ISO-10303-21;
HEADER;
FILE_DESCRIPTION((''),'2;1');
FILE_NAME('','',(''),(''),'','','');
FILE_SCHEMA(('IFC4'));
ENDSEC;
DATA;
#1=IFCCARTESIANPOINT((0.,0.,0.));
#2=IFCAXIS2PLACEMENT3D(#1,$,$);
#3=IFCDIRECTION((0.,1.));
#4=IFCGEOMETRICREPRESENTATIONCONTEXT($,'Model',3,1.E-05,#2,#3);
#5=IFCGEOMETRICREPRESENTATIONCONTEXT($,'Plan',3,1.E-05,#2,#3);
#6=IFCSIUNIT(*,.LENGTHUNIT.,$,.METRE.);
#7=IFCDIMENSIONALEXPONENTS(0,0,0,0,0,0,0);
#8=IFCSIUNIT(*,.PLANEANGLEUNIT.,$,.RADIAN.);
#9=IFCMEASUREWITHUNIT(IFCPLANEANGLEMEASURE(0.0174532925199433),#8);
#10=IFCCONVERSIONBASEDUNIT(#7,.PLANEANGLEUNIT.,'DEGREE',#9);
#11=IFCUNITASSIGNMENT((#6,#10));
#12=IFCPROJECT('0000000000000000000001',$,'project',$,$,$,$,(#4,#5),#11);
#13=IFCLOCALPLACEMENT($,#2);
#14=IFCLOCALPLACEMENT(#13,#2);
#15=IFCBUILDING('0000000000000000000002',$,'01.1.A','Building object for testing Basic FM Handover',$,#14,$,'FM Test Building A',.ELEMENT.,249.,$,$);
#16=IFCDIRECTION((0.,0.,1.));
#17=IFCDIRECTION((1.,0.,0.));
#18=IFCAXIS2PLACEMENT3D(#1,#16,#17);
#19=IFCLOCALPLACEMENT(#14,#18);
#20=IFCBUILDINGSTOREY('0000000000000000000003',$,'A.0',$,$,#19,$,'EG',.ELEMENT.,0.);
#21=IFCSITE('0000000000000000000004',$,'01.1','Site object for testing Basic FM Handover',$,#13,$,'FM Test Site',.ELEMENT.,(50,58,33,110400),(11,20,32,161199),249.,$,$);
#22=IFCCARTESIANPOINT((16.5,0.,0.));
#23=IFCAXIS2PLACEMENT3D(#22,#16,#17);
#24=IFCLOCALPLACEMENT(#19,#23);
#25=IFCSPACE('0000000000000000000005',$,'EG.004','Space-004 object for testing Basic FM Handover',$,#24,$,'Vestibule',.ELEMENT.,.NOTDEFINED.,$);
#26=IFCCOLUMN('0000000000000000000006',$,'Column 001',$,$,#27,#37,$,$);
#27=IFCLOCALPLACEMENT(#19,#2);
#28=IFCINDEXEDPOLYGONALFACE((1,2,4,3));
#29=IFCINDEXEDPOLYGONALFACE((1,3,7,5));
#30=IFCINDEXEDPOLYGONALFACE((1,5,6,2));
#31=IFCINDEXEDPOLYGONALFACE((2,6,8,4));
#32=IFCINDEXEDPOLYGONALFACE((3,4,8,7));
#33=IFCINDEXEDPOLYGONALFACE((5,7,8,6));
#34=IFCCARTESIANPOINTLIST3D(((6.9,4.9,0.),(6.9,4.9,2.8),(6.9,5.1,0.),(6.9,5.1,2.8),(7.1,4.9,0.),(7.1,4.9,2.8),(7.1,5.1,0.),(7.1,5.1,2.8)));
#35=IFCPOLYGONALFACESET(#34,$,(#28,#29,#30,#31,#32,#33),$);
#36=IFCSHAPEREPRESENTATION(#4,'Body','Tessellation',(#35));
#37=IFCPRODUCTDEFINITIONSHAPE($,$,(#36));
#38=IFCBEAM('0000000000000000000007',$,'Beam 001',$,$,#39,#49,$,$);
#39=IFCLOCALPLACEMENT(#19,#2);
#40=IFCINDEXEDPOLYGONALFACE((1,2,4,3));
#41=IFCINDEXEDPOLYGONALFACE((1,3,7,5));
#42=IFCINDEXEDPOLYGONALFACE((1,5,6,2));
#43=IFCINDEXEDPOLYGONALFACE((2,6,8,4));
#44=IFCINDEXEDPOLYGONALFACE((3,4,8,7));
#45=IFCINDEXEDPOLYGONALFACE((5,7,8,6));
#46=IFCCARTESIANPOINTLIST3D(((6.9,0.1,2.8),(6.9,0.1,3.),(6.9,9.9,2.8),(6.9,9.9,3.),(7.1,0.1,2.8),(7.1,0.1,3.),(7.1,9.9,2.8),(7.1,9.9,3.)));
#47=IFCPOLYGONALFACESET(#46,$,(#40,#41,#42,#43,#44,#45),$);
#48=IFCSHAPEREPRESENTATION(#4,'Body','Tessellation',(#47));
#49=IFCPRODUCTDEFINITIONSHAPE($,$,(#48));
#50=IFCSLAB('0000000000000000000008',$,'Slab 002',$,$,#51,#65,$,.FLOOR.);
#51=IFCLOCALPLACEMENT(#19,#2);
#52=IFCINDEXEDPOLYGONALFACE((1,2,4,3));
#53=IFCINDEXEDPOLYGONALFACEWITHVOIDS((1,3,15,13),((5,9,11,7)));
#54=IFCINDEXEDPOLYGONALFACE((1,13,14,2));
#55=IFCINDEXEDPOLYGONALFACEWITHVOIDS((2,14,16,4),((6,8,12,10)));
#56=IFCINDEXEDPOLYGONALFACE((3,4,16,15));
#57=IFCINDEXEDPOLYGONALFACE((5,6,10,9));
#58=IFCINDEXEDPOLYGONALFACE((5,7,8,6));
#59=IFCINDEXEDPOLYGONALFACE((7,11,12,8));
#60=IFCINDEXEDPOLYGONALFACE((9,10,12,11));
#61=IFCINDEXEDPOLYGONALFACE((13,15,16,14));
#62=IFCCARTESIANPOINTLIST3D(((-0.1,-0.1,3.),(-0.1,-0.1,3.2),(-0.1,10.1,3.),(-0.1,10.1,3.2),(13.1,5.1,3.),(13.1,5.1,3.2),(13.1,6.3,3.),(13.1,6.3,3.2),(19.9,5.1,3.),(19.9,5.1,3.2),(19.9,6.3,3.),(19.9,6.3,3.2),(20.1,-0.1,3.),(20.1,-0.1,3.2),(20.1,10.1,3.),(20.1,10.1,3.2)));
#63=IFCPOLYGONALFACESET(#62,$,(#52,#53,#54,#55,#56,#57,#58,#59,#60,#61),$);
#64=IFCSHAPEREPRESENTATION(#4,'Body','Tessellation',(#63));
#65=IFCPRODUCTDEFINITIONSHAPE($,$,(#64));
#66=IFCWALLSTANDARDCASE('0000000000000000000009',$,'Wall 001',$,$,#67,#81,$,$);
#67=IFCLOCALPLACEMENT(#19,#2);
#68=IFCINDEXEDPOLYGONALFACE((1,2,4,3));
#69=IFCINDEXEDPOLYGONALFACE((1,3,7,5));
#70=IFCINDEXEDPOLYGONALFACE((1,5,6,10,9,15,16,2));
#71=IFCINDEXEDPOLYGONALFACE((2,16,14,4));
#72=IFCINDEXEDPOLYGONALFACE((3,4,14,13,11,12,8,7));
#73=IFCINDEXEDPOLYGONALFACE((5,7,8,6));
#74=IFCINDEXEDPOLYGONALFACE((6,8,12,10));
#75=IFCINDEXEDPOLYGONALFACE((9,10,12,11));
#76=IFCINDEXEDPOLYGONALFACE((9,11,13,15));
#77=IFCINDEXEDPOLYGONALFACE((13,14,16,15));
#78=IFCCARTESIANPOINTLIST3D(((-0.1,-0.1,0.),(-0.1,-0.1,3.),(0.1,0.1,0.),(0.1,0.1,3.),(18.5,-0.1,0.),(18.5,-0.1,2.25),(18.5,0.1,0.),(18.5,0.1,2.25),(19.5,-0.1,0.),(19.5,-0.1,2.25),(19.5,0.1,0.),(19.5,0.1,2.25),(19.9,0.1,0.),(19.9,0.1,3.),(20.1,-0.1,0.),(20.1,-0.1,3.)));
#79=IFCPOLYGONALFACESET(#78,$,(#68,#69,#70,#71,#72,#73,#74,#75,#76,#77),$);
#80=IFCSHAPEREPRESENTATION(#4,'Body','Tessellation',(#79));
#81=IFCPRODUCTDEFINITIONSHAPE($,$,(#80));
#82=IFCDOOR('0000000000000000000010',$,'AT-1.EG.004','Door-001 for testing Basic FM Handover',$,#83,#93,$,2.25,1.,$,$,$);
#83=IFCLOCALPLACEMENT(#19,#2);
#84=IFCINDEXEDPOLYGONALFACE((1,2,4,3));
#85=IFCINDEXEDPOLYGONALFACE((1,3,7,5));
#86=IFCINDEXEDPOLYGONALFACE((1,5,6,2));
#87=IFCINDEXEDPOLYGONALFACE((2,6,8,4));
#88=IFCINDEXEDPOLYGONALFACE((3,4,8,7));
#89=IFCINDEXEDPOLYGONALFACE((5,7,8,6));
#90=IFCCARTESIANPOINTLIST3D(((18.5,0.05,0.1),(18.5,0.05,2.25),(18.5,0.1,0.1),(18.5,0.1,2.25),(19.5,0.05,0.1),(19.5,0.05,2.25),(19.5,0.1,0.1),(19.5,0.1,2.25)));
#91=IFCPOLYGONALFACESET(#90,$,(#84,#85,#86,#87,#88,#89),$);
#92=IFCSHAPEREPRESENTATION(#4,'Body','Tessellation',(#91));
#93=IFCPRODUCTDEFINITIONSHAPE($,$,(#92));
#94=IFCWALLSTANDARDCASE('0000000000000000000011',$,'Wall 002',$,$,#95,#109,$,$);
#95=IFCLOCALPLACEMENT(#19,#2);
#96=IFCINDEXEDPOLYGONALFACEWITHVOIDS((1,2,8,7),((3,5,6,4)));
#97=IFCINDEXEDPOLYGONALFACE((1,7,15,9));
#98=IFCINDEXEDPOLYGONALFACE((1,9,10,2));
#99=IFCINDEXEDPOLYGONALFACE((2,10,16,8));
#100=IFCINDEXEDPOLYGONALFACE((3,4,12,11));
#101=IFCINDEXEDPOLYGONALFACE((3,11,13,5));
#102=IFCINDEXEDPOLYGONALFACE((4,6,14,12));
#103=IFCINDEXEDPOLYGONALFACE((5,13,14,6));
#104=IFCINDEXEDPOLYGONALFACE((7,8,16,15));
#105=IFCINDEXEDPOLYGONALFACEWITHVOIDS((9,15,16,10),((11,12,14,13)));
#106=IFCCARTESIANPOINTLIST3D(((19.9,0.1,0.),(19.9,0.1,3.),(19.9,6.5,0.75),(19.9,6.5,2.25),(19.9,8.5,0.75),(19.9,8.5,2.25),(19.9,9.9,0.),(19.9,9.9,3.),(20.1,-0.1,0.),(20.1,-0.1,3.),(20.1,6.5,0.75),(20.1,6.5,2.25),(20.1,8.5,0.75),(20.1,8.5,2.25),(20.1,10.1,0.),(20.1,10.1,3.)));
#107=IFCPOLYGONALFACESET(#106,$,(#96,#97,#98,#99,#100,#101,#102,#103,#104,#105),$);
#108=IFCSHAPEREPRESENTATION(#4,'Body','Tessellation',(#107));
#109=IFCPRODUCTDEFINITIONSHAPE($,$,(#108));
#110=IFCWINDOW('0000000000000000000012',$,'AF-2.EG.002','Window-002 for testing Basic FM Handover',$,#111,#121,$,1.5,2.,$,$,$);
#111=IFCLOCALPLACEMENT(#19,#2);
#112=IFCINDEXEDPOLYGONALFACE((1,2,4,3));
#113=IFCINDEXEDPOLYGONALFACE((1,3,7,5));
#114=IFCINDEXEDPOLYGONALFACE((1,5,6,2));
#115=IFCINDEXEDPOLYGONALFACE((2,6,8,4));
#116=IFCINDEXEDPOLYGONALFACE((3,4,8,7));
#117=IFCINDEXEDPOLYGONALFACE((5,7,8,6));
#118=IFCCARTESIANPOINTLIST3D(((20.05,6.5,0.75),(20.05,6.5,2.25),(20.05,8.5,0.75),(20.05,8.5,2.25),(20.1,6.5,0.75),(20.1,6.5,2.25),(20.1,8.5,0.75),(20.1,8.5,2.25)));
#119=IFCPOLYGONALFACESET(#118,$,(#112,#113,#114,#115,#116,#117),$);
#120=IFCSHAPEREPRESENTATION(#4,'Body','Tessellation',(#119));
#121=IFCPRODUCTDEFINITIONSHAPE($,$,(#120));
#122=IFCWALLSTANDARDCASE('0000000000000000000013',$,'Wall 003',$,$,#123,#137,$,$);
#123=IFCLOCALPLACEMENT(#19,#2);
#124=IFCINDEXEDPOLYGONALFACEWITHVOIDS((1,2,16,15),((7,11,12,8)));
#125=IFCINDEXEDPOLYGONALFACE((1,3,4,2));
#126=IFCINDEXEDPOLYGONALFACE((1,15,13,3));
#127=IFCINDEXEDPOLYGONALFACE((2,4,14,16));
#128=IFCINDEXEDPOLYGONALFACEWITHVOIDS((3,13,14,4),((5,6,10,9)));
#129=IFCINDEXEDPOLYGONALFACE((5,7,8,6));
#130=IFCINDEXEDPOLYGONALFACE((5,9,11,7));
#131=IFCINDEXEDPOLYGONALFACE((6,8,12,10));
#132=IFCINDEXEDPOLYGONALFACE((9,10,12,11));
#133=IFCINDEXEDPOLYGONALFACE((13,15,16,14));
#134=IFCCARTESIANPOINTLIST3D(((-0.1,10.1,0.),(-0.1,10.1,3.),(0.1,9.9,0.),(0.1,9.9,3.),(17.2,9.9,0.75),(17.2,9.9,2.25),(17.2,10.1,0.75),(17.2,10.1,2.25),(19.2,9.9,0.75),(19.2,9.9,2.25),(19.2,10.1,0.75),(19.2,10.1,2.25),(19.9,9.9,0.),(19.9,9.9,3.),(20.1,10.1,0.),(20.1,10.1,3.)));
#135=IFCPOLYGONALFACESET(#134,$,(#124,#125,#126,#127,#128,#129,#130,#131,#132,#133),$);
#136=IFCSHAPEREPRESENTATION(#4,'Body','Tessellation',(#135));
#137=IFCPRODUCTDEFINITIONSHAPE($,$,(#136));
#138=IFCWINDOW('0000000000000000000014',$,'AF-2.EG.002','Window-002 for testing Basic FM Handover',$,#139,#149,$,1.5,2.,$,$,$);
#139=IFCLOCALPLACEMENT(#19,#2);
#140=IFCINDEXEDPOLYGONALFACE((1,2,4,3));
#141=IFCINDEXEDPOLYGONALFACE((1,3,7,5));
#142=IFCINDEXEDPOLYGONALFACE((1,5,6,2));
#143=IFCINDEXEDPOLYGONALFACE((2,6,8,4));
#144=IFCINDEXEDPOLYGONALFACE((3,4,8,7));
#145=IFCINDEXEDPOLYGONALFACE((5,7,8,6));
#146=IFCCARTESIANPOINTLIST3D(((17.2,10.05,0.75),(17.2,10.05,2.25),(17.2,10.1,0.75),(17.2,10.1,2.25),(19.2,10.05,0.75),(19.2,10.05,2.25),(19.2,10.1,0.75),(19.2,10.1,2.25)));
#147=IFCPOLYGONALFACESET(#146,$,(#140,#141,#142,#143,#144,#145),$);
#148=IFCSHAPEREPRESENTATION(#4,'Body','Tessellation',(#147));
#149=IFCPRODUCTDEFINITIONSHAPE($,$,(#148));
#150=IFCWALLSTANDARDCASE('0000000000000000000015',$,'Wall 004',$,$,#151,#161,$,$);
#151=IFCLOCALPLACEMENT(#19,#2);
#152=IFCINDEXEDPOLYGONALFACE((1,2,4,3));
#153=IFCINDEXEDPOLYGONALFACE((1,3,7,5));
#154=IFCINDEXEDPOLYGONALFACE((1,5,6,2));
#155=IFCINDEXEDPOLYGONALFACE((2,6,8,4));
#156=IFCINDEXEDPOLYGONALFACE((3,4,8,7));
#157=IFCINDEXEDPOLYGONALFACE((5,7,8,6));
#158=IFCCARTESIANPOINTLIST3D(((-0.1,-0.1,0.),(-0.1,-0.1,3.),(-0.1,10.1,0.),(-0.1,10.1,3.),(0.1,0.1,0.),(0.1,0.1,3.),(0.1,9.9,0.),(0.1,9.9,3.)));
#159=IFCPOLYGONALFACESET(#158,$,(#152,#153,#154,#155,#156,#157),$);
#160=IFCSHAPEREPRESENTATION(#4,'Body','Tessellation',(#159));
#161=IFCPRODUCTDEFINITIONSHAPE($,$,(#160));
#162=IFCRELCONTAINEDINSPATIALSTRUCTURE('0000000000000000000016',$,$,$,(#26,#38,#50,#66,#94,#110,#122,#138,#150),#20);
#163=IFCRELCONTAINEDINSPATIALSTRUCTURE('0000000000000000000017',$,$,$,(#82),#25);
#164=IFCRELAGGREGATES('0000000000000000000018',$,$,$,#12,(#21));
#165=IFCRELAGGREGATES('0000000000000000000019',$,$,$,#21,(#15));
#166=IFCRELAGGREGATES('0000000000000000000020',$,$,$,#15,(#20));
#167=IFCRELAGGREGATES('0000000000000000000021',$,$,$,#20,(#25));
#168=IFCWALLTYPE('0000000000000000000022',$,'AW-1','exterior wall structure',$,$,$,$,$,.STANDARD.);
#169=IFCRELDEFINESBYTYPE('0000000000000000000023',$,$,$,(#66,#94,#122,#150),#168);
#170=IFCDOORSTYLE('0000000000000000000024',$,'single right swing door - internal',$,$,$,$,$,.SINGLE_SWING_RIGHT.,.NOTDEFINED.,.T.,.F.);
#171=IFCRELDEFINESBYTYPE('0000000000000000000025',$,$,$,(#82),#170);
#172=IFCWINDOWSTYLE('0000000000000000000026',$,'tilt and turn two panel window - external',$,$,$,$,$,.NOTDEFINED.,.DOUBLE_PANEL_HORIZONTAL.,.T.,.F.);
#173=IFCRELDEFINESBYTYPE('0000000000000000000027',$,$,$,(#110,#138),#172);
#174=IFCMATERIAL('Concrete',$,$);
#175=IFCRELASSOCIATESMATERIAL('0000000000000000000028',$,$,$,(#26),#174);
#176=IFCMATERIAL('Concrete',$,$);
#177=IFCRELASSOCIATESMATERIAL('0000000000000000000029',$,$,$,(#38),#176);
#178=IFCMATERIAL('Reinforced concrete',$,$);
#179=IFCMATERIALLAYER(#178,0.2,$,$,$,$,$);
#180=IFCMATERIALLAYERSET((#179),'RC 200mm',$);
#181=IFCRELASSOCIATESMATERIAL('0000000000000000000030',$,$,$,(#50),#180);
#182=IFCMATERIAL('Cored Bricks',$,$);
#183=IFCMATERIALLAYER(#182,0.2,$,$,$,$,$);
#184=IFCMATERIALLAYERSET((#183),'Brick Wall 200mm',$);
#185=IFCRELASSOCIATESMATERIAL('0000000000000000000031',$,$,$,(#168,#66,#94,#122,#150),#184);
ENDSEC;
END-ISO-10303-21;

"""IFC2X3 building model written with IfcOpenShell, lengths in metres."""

from ifc_helpers import new_model, entity, si_unit, converted_unit, direction, frame, frame_2d, origin, origin_with_axes, origin_2d, place, context, project, spatial, polyline, rectangle, outline, extrude, material, layer, layer_set, layer_usage, type_object, element, fill, save


model = new_model("IFC2X3")

# Units and contexts
model_context = context("Model", 3, precision=1e-05, world=origin(), true_north=direction((0.0, 1.0)))
plan_context = context("Plan", 3, precision=1e-05, world=origin(), true_north=direction((0.0, 1.0)))
ifc_project = project(units=[si_unit("LENGTHUNIT", "METRE"), converted_unit("PLANEANGLEUNIT", "DEGREE", entity("IfcPlaneAngleMeasure", 0.0174532925199433), si_unit("PLANEANGLEUNIT", "RADIAN"), dimensions=[0, 0, 0, 0, 0, 0, 0])], contexts=[model_context, plan_context])

# Site, building, storey
site_placement = place(None, origin())
site = spatial("IfcSite", under=ifc_project, at=site_placement, Name="01.1", Description="Site object for testing Basic FM Handover", LongName="FM Test Site", CompositionType="ELEMENT", RefLatitude=(50, 58, 33, 110400), RefLongitude=(11, 20, 32, 161199), RefElevation=249.0)
building_placement = place(site_placement, origin())
building = spatial("IfcBuilding", under=site, at=building_placement, Name="01.1.A", Description="Building object for testing Basic FM Handover", LongName="FM Test Building A", CompositionType="ELEMENT", ElevationOfRefHeight=249.0)
storey_placement = place(building_placement, origin_with_axes())
storey = spatial("IfcBuildingStorey", under=building, at=storey_placement, Name="A.0", LongName="EG", CompositionType="ELEMENT", Elevation=0.0)

# Column
ifc_material_1 = material(Name="Concrete")
column_placement = place(storey_placement, frame((7.0, 5.0, 0.0), z_axis=(0.0, 0.0, 1.0), x_axis=(1.0, 0.0, 0.0)))
element("IfcColumn", 1, at=column_placement, inside=storey, material=ifc_material_1, Name="Column 001", context=model_context, shape_type="SweptSolid", body=[
    extrude(rectangle(XDim=0.2, YDim=0.2, at=origin_2d()), origin(), (0.0, 0.0, 1.0), 2.8),
])

# Beam
ifc_material_2 = material(Name="Concrete")
beam_placement = place(storey_placement, frame((7.0, 9.9, 2.9), z_axis=(0.0, -1.0, 0.0), x_axis=(1.0, 0.0, 0.0)))
element("IfcBeam", 2, at=beam_placement, inside=storey, material=ifc_material_2, Name="Beam 001", context=model_context, shape_type="SweptSolid", body=[
    extrude(rectangle(XDim=0.2, YDim=0.2, at=origin_2d()), origin(), (0.0, 0.0, 1.0), 9.8),
])

# Slab, opening
ifc_material_3 = material(Name="Reinforced concrete")
ifc_layer_1 = layer(ifc_material_3, 0.2)
ifc_layer_set_1 = layer_set([ifc_layer_1], Name="RC 200mm")
ifc_layer_usage_1 = layer_usage(ifc_layer_set_1, "AXIS3", "POSITIVE", 0.0)
slab_placement = place(storey_placement, frame((0.0, 0.0, 3.0), z_axis=(0.0, 0.0, 1.0), x_axis=(1.0, 0.0, 0.0)))
slab = element("IfcSlab", 3, at=slab_placement, inside=storey, material=ifc_layer_usage_1, Name="Slab 002", PredefinedType="FLOOR", context=model_context, shape_type="SweptSolid", body=[
    extrude(outline(polyline([(-0.1, -0.1), (20.1, -0.1), (20.1, 10.1), (-0.1, 10.1), (-0.1, -0.1)])), origin(), (0.0, 0.0, 1.0), 0.2),
])
opening_1_placement = place(slab_placement, frame((13.1, 5.1, 0.0), z_axis=(0.0, 0.0, 1.0), x_axis=(1.0, 0.0, 0.0)))
element("IfcOpeningElement", 4, at=opening_1_placement, cuts=slab, context=model_context, shape_type="SweptSolid", body=[
    extrude(outline(polyline([(0.0, 0.0), (6.8, 0.0), (6.8, 1.2), (0.0, 1.2), (0.0, 0.0)])), origin(), (0.0, 0.0, 1.0), 0.2),
])

# Wall, opening
ifc_material_4 = material(Name="Cored Bricks")
ifc_layer_2 = layer(ifc_material_4, 0.2)
ifc_layer_set_2 = layer_set([ifc_layer_2], Name="Brick Wall 200mm")
ifc_layer_usage_2 = layer_usage(ifc_layer_set_2, "AXIS2", "POSITIVE", -0.1)
wall_type_1 = type_object("IfcWallType", Name="AW-1", Description="exterior wall structure", PredefinedType="STANDARD", material=ifc_layer_set_2)
wall_1_placement = place(storey_placement, origin_with_axes())
wall_1 = element("IfcWallStandardCase", 5, at=wall_1_placement, inside=storey, type_object=wall_type_1, material=ifc_layer_usage_2, Name="Wall 001", context=model_context, shape_type="SweptSolid", body=[
    extrude(outline(polyline([(-0.1, -0.1), (20.1, -0.1), (19.9, 0.1), (0.1, 0.1), (-0.1, -0.1)])), origin(), (0.0, 0.0, 1.0), 3.0),
])
opening_2_placement = place(wall_1_placement, frame((18.5, -0.1, 0.0), z_axis=(0.0, 1.0, 0.0), x_axis=(0.0, 0.0, 1.0)))
opening_2 = element("IfcOpeningElement", 6, at=opening_2_placement, cuts=wall_1, context=model_context, shape_type="SweptSolid", body=[
    extrude(rectangle(XDim=2.25, YDim=1.0, at=frame_2d((1.125, 0.5))), origin(), (0.0, 0.0, 1.0), 0.2),
])

# Shared definitions
space_1_placement = place(storey_placement, frame((16.5, 0.0, 0.0), z_axis=(0.0, 0.0, 1.0), x_axis=(1.0, 0.0, 0.0)))
space_1 = spatial("IfcSpace", under=storey, at=space_1_placement, Name="EG.004", Description="Space-004 object for testing Basic FM Handover", LongName="Vestibule", CompositionType="ELEMENT", InteriorOrExteriorSpace="NOTDEFINED")

# Door
door_style_1 = type_object("IfcDoorStyle", Name="single right swing door - internal", ConstructionType="NOTDEFINED", OperationType="SINGLE_SWING_RIGHT", ParameterTakesPrecedence=True, Sizeable=False)
door_1_placement = place(opening_2_placement, frame((0.0, 0.0, 0.0), z_axis=(1.0, 0.0, 0.0), x_axis=(0.0, 1.0, 0.0)))
door_1 = element("IfcDoor", 7, at=door_1_placement, inside=space_1, type_object=door_style_1, Name="AT-1.EG.004", Description="Door-001 for testing Basic FM Handover", OverallHeight=2.25, OverallWidth=1.0, context=model_context, shape_type="SweptSolid", body=[
    extrude(rectangle(XDim=2.15, YDim=1.0, at=frame_2d((1.075, 0.5))), frame((0.0, 0.15, 0.1), z_axis=(0.0, 1.0, 0.0), x_axis=(0.0, 0.0, 1.0)), (0.0, 0.0, 1.0), 0.05),
])
fill(opening_2, door_1)

# Walls, openings, windows
ifc_layer_usage_3 = layer_usage(ifc_layer_set_2, "AXIS2", "POSITIVE", -0.1)
wall_2_placement = place(storey_placement, frame((20.0, 0.0, 0.0), z_axis=(0.0, 0.0, 1.0), x_axis=(0.0, 1.0, 0.0)))
wall_2 = element("IfcWallStandardCase", 8, at=wall_2_placement, inside=storey, type_object=wall_type_1, material=ifc_layer_usage_3, Name="Wall 002", context=model_context, shape_type="SweptSolid", body=[
    extrude(outline(polyline([(-0.1, -0.1), (10.1, -0.1), (9.9, 0.1), (0.1, 0.1), (-0.1, -0.1)])), origin(), (0.0, 0.0, 1.0), 3.0),
])
opening_3_placement = place(wall_2_placement, frame((6.5, -0.1, 0.75), z_axis=(0.0, 0.0, 1.0), x_axis=(1.0, 0.0, 0.0)))
opening_3 = element("IfcOpeningElement", 9, at=opening_3_placement, cuts=wall_2, context=model_context, shape_type="SweptSolid", body=[
    extrude(rectangle(XDim=1.5, YDim=2.0, at=frame_2d((0.75, 1.0))), frame((0.0, 0.0, 0.0), z_axis=(0.0, 1.0, 0.0), x_axis=(0.0, 0.0, 1.0)), (0.0, 0.0, 1.0), 0.2),
])
window_style = type_object("IfcWindowStyle", Name="tilt and turn two panel window - external", ConstructionType="NOTDEFINED", OperationType="DOUBLE_PANEL_HORIZONTAL", ParameterTakesPrecedence=True, Sizeable=False)
window_1_placement = place(opening_3_placement, origin_with_axes())
window_1 = element("IfcWindow", 10, at=window_1_placement, inside=storey, type_object=window_style, Name="AF-2.EG.002", Description="Window-002 for testing Basic FM Handover", OverallHeight=1.5, OverallWidth=2.0, context=model_context, shape_type="SweptSolid", body=[
    extrude(rectangle(XDim=1.5, YDim=2.0, at=frame_2d((0.75, 1.0))), frame((0.0, 0.0, 0.0), z_axis=(0.0, 1.0, 0.0), x_axis=(0.0, 0.0, 1.0)), (0.0, 0.0, 1.0), 0.05),
])
fill(opening_3, window_1)
ifc_layer_usage_4 = layer_usage(ifc_layer_set_2, "AXIS2", "POSITIVE", -0.1)
wall_3_placement = place(storey_placement, frame((20.0, 10.0, 0.0), z_axis=(0.0, 0.0, 1.0), x_axis=(-1.0, 0.0, 0.0)))
wall_3 = element("IfcWallStandardCase", 11, at=wall_3_placement, inside=storey, type_object=wall_type_1, material=ifc_layer_usage_4, Name="Wall 003", context=model_context, shape_type="SweptSolid", body=[
    extrude(outline(polyline([(-0.1, -0.1), (20.1, -0.1), (19.9, 0.1), (0.1, 0.1), (-0.1, -0.1)])), origin(), (0.0, 0.0, 1.0), 3.0),
])
opening_4_placement = place(wall_3_placement, frame((0.8, -0.1, 0.75), z_axis=(0.0, 0.0, 1.0), x_axis=(1.0, 0.0, 0.0)))
opening_4 = element("IfcOpeningElement", 12, at=opening_4_placement, cuts=wall_3, context=model_context, shape_type="SweptSolid", body=[
    extrude(rectangle(XDim=1.5, YDim=2.0, at=frame_2d((0.75, 1.0))), frame((0.0, 0.0, 0.0), z_axis=(0.0, 1.0, 0.0), x_axis=(0.0, 0.0, 1.0)), (0.0, 0.0, 1.0), 0.2),
])
window_2_placement = place(opening_4_placement, origin_with_axes())
window_2 = element("IfcWindow", 13, at=window_2_placement, inside=storey, type_object=window_style, Name="AF-2.EG.002", Description="Window-002 for testing Basic FM Handover", OverallHeight=1.5, OverallWidth=2.0, context=model_context, shape_type="SweptSolid", body=[
    extrude(rectangle(XDim=1.5, YDim=2.0, at=frame_2d((0.75, 1.0))), frame((0.0, 0.0, 0.0), z_axis=(0.0, 1.0, 0.0), x_axis=(0.0, 0.0, 1.0)), (0.0, 0.0, 1.0), 0.05),
])
fill(opening_4, window_2)

# Wall
ifc_layer_usage_5 = layer_usage(ifc_layer_set_2, "AXIS2", "POSITIVE", -0.1)
wall_4_placement = place(storey_placement, frame((0.0, 10.0, 0.0), z_axis=(0.0, 0.0, 1.0), x_axis=(0.0, -1.0, 0.0)))
element("IfcWallStandardCase", 14, at=wall_4_placement, inside=storey, type_object=wall_type_1, material=ifc_layer_usage_5, Name="Wall 004", context=model_context, shape_type="SweptSolid", body=[
    extrude(outline(polyline([(-0.1, -0.1), (10.1, -0.1), (9.9, 0.1), (0.1, 0.1), (-0.1, -0.1)])), origin(), (0.0, 0.0, 1.0), 3.0),
])

save(model, "model.ifc")
